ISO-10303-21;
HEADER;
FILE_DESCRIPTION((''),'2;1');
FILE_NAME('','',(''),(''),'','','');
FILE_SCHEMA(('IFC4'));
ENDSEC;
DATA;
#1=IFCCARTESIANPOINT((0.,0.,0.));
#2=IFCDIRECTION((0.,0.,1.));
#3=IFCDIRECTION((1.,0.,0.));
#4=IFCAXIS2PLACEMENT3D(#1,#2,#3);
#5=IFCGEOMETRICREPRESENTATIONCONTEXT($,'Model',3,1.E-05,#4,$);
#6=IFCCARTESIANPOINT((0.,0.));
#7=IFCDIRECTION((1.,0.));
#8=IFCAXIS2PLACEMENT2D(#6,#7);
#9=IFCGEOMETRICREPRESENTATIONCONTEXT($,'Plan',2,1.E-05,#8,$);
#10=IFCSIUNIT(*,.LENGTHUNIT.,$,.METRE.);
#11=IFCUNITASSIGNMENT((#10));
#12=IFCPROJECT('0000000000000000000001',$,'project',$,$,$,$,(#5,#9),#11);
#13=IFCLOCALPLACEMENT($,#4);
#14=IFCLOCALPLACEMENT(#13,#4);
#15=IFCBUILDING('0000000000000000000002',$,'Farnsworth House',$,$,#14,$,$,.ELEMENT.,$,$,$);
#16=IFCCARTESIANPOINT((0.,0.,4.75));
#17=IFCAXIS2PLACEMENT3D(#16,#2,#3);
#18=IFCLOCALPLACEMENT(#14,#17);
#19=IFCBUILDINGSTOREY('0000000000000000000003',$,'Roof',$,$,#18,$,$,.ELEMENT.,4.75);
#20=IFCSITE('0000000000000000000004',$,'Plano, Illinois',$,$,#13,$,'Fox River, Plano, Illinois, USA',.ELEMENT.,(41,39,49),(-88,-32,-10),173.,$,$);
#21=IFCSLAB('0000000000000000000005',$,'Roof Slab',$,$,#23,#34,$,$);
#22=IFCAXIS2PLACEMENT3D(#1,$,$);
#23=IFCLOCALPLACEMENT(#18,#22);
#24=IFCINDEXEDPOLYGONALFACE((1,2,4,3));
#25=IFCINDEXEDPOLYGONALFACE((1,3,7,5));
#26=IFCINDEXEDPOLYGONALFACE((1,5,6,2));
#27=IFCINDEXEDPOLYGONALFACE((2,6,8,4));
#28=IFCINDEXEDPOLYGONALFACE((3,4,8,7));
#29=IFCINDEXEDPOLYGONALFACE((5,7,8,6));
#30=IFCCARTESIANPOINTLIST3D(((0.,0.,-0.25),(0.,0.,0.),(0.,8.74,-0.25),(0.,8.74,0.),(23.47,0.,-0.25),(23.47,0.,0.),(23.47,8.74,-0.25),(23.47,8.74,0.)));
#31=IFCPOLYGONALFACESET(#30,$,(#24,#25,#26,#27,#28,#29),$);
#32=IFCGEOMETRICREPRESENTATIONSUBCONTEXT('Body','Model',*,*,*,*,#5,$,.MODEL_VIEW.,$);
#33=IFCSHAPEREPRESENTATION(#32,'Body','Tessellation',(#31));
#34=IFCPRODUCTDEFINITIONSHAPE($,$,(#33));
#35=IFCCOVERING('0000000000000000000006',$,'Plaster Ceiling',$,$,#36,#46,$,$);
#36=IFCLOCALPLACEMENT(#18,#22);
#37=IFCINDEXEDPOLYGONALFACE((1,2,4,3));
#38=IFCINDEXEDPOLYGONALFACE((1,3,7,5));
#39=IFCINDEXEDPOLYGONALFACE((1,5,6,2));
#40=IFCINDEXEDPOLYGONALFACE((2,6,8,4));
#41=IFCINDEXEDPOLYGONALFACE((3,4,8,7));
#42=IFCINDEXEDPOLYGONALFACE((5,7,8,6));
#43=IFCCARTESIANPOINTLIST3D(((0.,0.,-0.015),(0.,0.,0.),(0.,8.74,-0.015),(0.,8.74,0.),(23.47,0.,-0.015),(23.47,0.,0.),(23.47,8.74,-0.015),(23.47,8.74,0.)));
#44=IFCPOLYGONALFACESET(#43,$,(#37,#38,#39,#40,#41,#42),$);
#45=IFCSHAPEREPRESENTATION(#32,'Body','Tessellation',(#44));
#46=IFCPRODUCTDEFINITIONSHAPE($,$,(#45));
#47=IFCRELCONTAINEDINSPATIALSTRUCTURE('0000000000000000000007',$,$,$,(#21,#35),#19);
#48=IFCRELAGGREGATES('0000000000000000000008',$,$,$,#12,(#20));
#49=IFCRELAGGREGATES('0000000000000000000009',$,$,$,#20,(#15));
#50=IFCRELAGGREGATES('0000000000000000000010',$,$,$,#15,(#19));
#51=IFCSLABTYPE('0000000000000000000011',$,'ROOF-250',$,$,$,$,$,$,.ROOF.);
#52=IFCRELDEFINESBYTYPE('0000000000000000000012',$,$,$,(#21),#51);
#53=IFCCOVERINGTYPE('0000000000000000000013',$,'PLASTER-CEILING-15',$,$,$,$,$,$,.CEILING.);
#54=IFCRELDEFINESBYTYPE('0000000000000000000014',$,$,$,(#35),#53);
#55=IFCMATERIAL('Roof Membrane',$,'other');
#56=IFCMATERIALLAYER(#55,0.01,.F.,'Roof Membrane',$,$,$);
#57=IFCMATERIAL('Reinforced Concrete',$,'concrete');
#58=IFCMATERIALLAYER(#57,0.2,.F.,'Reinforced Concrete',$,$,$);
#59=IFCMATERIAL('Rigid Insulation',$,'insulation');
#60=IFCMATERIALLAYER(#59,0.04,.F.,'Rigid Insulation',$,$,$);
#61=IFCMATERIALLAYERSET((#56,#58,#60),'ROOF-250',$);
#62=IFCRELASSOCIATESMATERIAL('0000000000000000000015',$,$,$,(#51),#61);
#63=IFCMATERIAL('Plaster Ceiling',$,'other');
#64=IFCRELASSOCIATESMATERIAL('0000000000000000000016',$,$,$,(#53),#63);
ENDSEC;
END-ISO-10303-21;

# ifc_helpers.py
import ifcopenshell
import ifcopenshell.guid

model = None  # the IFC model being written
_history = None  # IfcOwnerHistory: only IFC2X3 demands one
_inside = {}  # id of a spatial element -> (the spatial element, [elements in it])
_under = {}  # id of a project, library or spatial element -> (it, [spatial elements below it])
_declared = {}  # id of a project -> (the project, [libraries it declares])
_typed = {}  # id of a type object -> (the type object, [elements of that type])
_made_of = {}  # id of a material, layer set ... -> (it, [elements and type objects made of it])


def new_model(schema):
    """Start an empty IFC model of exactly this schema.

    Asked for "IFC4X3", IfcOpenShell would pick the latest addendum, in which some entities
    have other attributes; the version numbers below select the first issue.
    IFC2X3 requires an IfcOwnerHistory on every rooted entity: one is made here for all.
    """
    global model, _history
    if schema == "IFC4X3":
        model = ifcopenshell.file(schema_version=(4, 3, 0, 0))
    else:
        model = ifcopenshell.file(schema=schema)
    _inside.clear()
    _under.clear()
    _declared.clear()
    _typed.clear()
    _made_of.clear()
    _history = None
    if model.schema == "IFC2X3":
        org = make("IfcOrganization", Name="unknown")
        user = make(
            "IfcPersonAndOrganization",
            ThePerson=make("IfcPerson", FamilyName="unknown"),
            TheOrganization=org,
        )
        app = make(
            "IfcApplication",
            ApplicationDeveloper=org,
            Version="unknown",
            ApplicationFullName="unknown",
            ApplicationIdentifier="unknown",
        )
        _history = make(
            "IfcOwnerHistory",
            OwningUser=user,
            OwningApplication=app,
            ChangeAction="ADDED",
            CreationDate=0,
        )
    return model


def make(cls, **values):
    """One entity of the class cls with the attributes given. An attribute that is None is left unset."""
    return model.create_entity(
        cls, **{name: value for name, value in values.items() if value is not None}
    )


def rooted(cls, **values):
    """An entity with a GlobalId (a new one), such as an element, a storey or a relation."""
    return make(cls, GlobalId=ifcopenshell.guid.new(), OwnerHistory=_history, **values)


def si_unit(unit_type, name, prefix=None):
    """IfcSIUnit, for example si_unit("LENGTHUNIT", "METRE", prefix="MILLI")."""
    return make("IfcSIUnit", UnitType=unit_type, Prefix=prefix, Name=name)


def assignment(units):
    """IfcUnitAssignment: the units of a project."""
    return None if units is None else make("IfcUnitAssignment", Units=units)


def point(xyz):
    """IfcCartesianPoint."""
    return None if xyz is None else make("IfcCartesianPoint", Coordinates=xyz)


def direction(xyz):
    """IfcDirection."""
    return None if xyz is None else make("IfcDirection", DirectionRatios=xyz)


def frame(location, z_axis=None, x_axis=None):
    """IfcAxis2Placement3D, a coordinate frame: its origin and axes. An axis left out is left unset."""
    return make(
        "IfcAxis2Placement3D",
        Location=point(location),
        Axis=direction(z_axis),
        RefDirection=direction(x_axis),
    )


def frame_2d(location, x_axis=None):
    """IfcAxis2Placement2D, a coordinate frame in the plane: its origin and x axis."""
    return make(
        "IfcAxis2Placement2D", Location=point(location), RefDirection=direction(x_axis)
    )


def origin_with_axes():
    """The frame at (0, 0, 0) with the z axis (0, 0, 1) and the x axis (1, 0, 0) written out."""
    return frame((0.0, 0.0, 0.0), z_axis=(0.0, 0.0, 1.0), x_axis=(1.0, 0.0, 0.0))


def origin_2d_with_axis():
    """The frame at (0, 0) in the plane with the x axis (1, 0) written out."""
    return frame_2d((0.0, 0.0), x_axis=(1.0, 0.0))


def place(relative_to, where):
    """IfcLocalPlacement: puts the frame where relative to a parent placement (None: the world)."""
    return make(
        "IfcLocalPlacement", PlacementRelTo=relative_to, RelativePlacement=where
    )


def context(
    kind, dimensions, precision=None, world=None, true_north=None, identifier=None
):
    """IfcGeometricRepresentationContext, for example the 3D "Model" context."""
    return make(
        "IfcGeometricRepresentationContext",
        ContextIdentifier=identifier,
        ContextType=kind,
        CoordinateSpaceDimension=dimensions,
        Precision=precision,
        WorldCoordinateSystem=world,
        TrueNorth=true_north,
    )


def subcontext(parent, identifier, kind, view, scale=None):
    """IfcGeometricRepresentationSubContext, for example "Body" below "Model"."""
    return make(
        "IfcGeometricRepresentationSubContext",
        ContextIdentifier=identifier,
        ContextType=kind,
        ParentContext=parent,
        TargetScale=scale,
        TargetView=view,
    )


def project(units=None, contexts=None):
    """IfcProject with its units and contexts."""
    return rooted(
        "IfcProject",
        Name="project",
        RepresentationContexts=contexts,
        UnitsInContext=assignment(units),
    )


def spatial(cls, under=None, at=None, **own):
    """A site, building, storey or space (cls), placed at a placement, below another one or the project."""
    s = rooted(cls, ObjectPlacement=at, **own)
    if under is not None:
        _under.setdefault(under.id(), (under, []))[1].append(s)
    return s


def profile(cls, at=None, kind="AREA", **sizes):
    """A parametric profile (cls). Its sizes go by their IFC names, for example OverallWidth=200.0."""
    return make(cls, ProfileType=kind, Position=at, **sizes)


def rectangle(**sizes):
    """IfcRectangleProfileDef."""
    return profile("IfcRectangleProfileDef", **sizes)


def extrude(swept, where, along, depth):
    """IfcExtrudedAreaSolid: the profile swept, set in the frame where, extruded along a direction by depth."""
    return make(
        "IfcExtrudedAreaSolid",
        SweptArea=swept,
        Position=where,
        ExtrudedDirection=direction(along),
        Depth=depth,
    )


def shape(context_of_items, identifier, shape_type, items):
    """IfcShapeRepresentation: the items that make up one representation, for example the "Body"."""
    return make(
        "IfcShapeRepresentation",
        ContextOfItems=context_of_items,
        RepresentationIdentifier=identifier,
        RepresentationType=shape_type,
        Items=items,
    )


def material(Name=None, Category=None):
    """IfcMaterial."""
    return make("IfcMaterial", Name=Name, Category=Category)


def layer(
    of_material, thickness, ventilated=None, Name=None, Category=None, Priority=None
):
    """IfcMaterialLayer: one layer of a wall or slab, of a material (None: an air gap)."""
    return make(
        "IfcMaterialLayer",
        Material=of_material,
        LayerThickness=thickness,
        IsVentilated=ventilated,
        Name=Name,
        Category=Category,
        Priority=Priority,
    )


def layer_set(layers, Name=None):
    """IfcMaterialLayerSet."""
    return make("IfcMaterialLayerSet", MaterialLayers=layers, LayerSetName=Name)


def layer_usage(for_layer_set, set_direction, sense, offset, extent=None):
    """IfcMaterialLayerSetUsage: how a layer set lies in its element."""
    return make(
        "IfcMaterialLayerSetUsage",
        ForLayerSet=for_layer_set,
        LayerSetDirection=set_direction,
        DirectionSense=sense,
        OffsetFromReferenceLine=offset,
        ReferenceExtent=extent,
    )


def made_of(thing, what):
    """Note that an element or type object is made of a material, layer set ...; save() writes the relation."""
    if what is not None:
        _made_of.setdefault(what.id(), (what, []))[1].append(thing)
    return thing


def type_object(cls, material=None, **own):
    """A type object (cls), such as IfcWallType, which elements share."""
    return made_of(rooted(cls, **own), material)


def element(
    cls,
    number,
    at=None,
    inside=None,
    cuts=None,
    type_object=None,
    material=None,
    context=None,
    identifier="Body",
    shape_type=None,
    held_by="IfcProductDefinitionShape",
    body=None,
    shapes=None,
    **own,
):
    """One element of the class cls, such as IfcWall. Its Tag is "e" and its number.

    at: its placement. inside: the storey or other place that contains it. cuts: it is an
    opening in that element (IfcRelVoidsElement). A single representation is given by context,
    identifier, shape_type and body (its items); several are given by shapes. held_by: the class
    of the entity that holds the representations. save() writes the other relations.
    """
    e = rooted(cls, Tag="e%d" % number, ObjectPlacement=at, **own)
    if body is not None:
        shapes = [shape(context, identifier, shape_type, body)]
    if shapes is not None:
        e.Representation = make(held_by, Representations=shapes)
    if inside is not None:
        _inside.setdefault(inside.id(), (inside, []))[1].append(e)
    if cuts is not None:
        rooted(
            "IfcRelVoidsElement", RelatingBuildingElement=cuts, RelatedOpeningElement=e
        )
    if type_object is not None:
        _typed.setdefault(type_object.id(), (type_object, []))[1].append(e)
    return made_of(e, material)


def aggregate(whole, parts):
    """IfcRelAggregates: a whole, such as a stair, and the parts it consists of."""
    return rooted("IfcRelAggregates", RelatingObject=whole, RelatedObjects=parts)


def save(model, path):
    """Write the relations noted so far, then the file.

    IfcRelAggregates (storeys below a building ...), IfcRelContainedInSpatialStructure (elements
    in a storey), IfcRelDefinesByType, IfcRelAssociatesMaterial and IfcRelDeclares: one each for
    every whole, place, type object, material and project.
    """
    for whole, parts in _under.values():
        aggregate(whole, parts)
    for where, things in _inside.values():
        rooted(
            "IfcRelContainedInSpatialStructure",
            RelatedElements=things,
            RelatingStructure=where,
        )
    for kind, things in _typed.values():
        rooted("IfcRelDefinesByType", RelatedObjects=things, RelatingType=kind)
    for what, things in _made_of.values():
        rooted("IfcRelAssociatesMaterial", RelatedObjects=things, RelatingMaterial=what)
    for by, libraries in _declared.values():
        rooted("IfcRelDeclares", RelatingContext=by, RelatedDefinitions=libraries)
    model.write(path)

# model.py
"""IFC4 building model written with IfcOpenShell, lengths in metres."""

from ifc_helpers import new_model, si_unit, frame, origin_with_axes, origin_2d_with_axis, place, context, subcontext, project, spatial, rectangle, extrude, material, layer, layer_set, layer_usage, type_object, element, save


model = new_model("IFC4")

# Units and contexts
model_context = context("Model", 3, precision=1e-05, world=origin_with_axes())
plan_context = context("Plan", 2, precision=1e-05, world=origin_2d_with_axis())
body_context = subcontext(model_context, "Body", "Model", "MODEL_VIEW")
ifc_project = project(units=[si_unit("LENGTHUNIT", "METRE")], contexts=[model_context, plan_context])

# Site, building, storey
site_placement = place(None, origin_with_axes())
site = spatial("IfcSite", under=ifc_project, at=site_placement, Name="Plano, Illinois", LongName="Fox River, Plano, Illinois, USA", CompositionType="ELEMENT", RefLatitude=(41, 39, 49), RefLongitude=(-88, -32, -10), RefElevation=173.0)
building_placement = place(site_placement, origin_with_axes())
building = spatial("IfcBuilding", under=site, at=building_placement, Name="Farnsworth House", CompositionType="ELEMENT")
storey_placement = place(building_placement, frame((0.0, 0.0, 4.75), z_axis=(0.0, 0.0, 1.0), x_axis=(1.0, 0.0, 0.0)))
storey = spatial("IfcBuildingStorey", under=building, at=storey_placement, Name="Roof", CompositionType="ELEMENT", Elevation=4.75)

# Slab
ifc_material_1 = material(Name="Roof Membrane", Category="other")
ifc_layer_1 = layer(ifc_material_1, 0.01, ventilated=False, Name="Roof Membrane")
ifc_material_2 = material(Name="Reinforced Concrete", Category="concrete")
ifc_layer_2 = layer(ifc_material_2, 0.2, ventilated=False, Name="Reinforced Concrete")
ifc_material_3 = material(Name="Rigid Insulation", Category="insulation")
ifc_layer_3 = layer(ifc_material_3, 0.04, ventilated=False, Name="Rigid Insulation")
ifc_layer_set = layer_set([ifc_layer_1, ifc_layer_2, ifc_layer_3], Name="ROOF-250")
ifc_layer_usage = layer_usage(ifc_layer_set, "AXIS3", "POSITIVE", -0.25)
slab_type = type_object("IfcSlabType", Name="ROOF-250", PredefinedType="ROOF", material=ifc_layer_usage)
slab_placement = place(storey_placement, frame((0.0, 0.0, -0.25), z_axis=(0.0, 0.0, 1.0), x_axis=(1.0, 0.0, 0.0)))
element("IfcSlab", 1, at=slab_placement, inside=storey, type_object=slab_type, Name="Roof Slab", context=body_context, shape_type="SweptSolid", body=[
    extrude(rectangle(XDim=23.47, YDim=8.74, at=origin_2d_with_axis()), frame((11.735, 4.37, 0.0), z_axis=(0.0, 0.0, 1.0), x_axis=(1.0, 0.0, 0.0)), (0.0, 0.0, 1.0), 0.25),
])

# Covering
ifc_material_4 = material(Name="Plaster Ceiling", Category="other")
covering_type = type_object("IfcCoveringType", Name="PLASTER-CEILING-15", PredefinedType="CEILING", material=ifc_material_4)
covering_placement = place(storey_placement, frame((0.0, 0.0, -0.015), z_axis=(0.0, 0.0, 1.0), x_axis=(1.0, 0.0, 0.0)))
element("IfcCovering", 2, at=covering_placement, inside=storey, type_object=covering_type, Name="Plaster Ceiling", context=body_context, shape_type="SweptSolid", body=[
    extrude(rectangle(XDim=23.47, YDim=8.74, at=origin_2d_with_axis()), frame((11.735, 4.37, 0.0), z_axis=(0.0, 0.0, 1.0), x_axis=(1.0, 0.0, 0.0)), (0.0, 0.0, 1.0), 0.015),
])

save(model, "model.ifc")
